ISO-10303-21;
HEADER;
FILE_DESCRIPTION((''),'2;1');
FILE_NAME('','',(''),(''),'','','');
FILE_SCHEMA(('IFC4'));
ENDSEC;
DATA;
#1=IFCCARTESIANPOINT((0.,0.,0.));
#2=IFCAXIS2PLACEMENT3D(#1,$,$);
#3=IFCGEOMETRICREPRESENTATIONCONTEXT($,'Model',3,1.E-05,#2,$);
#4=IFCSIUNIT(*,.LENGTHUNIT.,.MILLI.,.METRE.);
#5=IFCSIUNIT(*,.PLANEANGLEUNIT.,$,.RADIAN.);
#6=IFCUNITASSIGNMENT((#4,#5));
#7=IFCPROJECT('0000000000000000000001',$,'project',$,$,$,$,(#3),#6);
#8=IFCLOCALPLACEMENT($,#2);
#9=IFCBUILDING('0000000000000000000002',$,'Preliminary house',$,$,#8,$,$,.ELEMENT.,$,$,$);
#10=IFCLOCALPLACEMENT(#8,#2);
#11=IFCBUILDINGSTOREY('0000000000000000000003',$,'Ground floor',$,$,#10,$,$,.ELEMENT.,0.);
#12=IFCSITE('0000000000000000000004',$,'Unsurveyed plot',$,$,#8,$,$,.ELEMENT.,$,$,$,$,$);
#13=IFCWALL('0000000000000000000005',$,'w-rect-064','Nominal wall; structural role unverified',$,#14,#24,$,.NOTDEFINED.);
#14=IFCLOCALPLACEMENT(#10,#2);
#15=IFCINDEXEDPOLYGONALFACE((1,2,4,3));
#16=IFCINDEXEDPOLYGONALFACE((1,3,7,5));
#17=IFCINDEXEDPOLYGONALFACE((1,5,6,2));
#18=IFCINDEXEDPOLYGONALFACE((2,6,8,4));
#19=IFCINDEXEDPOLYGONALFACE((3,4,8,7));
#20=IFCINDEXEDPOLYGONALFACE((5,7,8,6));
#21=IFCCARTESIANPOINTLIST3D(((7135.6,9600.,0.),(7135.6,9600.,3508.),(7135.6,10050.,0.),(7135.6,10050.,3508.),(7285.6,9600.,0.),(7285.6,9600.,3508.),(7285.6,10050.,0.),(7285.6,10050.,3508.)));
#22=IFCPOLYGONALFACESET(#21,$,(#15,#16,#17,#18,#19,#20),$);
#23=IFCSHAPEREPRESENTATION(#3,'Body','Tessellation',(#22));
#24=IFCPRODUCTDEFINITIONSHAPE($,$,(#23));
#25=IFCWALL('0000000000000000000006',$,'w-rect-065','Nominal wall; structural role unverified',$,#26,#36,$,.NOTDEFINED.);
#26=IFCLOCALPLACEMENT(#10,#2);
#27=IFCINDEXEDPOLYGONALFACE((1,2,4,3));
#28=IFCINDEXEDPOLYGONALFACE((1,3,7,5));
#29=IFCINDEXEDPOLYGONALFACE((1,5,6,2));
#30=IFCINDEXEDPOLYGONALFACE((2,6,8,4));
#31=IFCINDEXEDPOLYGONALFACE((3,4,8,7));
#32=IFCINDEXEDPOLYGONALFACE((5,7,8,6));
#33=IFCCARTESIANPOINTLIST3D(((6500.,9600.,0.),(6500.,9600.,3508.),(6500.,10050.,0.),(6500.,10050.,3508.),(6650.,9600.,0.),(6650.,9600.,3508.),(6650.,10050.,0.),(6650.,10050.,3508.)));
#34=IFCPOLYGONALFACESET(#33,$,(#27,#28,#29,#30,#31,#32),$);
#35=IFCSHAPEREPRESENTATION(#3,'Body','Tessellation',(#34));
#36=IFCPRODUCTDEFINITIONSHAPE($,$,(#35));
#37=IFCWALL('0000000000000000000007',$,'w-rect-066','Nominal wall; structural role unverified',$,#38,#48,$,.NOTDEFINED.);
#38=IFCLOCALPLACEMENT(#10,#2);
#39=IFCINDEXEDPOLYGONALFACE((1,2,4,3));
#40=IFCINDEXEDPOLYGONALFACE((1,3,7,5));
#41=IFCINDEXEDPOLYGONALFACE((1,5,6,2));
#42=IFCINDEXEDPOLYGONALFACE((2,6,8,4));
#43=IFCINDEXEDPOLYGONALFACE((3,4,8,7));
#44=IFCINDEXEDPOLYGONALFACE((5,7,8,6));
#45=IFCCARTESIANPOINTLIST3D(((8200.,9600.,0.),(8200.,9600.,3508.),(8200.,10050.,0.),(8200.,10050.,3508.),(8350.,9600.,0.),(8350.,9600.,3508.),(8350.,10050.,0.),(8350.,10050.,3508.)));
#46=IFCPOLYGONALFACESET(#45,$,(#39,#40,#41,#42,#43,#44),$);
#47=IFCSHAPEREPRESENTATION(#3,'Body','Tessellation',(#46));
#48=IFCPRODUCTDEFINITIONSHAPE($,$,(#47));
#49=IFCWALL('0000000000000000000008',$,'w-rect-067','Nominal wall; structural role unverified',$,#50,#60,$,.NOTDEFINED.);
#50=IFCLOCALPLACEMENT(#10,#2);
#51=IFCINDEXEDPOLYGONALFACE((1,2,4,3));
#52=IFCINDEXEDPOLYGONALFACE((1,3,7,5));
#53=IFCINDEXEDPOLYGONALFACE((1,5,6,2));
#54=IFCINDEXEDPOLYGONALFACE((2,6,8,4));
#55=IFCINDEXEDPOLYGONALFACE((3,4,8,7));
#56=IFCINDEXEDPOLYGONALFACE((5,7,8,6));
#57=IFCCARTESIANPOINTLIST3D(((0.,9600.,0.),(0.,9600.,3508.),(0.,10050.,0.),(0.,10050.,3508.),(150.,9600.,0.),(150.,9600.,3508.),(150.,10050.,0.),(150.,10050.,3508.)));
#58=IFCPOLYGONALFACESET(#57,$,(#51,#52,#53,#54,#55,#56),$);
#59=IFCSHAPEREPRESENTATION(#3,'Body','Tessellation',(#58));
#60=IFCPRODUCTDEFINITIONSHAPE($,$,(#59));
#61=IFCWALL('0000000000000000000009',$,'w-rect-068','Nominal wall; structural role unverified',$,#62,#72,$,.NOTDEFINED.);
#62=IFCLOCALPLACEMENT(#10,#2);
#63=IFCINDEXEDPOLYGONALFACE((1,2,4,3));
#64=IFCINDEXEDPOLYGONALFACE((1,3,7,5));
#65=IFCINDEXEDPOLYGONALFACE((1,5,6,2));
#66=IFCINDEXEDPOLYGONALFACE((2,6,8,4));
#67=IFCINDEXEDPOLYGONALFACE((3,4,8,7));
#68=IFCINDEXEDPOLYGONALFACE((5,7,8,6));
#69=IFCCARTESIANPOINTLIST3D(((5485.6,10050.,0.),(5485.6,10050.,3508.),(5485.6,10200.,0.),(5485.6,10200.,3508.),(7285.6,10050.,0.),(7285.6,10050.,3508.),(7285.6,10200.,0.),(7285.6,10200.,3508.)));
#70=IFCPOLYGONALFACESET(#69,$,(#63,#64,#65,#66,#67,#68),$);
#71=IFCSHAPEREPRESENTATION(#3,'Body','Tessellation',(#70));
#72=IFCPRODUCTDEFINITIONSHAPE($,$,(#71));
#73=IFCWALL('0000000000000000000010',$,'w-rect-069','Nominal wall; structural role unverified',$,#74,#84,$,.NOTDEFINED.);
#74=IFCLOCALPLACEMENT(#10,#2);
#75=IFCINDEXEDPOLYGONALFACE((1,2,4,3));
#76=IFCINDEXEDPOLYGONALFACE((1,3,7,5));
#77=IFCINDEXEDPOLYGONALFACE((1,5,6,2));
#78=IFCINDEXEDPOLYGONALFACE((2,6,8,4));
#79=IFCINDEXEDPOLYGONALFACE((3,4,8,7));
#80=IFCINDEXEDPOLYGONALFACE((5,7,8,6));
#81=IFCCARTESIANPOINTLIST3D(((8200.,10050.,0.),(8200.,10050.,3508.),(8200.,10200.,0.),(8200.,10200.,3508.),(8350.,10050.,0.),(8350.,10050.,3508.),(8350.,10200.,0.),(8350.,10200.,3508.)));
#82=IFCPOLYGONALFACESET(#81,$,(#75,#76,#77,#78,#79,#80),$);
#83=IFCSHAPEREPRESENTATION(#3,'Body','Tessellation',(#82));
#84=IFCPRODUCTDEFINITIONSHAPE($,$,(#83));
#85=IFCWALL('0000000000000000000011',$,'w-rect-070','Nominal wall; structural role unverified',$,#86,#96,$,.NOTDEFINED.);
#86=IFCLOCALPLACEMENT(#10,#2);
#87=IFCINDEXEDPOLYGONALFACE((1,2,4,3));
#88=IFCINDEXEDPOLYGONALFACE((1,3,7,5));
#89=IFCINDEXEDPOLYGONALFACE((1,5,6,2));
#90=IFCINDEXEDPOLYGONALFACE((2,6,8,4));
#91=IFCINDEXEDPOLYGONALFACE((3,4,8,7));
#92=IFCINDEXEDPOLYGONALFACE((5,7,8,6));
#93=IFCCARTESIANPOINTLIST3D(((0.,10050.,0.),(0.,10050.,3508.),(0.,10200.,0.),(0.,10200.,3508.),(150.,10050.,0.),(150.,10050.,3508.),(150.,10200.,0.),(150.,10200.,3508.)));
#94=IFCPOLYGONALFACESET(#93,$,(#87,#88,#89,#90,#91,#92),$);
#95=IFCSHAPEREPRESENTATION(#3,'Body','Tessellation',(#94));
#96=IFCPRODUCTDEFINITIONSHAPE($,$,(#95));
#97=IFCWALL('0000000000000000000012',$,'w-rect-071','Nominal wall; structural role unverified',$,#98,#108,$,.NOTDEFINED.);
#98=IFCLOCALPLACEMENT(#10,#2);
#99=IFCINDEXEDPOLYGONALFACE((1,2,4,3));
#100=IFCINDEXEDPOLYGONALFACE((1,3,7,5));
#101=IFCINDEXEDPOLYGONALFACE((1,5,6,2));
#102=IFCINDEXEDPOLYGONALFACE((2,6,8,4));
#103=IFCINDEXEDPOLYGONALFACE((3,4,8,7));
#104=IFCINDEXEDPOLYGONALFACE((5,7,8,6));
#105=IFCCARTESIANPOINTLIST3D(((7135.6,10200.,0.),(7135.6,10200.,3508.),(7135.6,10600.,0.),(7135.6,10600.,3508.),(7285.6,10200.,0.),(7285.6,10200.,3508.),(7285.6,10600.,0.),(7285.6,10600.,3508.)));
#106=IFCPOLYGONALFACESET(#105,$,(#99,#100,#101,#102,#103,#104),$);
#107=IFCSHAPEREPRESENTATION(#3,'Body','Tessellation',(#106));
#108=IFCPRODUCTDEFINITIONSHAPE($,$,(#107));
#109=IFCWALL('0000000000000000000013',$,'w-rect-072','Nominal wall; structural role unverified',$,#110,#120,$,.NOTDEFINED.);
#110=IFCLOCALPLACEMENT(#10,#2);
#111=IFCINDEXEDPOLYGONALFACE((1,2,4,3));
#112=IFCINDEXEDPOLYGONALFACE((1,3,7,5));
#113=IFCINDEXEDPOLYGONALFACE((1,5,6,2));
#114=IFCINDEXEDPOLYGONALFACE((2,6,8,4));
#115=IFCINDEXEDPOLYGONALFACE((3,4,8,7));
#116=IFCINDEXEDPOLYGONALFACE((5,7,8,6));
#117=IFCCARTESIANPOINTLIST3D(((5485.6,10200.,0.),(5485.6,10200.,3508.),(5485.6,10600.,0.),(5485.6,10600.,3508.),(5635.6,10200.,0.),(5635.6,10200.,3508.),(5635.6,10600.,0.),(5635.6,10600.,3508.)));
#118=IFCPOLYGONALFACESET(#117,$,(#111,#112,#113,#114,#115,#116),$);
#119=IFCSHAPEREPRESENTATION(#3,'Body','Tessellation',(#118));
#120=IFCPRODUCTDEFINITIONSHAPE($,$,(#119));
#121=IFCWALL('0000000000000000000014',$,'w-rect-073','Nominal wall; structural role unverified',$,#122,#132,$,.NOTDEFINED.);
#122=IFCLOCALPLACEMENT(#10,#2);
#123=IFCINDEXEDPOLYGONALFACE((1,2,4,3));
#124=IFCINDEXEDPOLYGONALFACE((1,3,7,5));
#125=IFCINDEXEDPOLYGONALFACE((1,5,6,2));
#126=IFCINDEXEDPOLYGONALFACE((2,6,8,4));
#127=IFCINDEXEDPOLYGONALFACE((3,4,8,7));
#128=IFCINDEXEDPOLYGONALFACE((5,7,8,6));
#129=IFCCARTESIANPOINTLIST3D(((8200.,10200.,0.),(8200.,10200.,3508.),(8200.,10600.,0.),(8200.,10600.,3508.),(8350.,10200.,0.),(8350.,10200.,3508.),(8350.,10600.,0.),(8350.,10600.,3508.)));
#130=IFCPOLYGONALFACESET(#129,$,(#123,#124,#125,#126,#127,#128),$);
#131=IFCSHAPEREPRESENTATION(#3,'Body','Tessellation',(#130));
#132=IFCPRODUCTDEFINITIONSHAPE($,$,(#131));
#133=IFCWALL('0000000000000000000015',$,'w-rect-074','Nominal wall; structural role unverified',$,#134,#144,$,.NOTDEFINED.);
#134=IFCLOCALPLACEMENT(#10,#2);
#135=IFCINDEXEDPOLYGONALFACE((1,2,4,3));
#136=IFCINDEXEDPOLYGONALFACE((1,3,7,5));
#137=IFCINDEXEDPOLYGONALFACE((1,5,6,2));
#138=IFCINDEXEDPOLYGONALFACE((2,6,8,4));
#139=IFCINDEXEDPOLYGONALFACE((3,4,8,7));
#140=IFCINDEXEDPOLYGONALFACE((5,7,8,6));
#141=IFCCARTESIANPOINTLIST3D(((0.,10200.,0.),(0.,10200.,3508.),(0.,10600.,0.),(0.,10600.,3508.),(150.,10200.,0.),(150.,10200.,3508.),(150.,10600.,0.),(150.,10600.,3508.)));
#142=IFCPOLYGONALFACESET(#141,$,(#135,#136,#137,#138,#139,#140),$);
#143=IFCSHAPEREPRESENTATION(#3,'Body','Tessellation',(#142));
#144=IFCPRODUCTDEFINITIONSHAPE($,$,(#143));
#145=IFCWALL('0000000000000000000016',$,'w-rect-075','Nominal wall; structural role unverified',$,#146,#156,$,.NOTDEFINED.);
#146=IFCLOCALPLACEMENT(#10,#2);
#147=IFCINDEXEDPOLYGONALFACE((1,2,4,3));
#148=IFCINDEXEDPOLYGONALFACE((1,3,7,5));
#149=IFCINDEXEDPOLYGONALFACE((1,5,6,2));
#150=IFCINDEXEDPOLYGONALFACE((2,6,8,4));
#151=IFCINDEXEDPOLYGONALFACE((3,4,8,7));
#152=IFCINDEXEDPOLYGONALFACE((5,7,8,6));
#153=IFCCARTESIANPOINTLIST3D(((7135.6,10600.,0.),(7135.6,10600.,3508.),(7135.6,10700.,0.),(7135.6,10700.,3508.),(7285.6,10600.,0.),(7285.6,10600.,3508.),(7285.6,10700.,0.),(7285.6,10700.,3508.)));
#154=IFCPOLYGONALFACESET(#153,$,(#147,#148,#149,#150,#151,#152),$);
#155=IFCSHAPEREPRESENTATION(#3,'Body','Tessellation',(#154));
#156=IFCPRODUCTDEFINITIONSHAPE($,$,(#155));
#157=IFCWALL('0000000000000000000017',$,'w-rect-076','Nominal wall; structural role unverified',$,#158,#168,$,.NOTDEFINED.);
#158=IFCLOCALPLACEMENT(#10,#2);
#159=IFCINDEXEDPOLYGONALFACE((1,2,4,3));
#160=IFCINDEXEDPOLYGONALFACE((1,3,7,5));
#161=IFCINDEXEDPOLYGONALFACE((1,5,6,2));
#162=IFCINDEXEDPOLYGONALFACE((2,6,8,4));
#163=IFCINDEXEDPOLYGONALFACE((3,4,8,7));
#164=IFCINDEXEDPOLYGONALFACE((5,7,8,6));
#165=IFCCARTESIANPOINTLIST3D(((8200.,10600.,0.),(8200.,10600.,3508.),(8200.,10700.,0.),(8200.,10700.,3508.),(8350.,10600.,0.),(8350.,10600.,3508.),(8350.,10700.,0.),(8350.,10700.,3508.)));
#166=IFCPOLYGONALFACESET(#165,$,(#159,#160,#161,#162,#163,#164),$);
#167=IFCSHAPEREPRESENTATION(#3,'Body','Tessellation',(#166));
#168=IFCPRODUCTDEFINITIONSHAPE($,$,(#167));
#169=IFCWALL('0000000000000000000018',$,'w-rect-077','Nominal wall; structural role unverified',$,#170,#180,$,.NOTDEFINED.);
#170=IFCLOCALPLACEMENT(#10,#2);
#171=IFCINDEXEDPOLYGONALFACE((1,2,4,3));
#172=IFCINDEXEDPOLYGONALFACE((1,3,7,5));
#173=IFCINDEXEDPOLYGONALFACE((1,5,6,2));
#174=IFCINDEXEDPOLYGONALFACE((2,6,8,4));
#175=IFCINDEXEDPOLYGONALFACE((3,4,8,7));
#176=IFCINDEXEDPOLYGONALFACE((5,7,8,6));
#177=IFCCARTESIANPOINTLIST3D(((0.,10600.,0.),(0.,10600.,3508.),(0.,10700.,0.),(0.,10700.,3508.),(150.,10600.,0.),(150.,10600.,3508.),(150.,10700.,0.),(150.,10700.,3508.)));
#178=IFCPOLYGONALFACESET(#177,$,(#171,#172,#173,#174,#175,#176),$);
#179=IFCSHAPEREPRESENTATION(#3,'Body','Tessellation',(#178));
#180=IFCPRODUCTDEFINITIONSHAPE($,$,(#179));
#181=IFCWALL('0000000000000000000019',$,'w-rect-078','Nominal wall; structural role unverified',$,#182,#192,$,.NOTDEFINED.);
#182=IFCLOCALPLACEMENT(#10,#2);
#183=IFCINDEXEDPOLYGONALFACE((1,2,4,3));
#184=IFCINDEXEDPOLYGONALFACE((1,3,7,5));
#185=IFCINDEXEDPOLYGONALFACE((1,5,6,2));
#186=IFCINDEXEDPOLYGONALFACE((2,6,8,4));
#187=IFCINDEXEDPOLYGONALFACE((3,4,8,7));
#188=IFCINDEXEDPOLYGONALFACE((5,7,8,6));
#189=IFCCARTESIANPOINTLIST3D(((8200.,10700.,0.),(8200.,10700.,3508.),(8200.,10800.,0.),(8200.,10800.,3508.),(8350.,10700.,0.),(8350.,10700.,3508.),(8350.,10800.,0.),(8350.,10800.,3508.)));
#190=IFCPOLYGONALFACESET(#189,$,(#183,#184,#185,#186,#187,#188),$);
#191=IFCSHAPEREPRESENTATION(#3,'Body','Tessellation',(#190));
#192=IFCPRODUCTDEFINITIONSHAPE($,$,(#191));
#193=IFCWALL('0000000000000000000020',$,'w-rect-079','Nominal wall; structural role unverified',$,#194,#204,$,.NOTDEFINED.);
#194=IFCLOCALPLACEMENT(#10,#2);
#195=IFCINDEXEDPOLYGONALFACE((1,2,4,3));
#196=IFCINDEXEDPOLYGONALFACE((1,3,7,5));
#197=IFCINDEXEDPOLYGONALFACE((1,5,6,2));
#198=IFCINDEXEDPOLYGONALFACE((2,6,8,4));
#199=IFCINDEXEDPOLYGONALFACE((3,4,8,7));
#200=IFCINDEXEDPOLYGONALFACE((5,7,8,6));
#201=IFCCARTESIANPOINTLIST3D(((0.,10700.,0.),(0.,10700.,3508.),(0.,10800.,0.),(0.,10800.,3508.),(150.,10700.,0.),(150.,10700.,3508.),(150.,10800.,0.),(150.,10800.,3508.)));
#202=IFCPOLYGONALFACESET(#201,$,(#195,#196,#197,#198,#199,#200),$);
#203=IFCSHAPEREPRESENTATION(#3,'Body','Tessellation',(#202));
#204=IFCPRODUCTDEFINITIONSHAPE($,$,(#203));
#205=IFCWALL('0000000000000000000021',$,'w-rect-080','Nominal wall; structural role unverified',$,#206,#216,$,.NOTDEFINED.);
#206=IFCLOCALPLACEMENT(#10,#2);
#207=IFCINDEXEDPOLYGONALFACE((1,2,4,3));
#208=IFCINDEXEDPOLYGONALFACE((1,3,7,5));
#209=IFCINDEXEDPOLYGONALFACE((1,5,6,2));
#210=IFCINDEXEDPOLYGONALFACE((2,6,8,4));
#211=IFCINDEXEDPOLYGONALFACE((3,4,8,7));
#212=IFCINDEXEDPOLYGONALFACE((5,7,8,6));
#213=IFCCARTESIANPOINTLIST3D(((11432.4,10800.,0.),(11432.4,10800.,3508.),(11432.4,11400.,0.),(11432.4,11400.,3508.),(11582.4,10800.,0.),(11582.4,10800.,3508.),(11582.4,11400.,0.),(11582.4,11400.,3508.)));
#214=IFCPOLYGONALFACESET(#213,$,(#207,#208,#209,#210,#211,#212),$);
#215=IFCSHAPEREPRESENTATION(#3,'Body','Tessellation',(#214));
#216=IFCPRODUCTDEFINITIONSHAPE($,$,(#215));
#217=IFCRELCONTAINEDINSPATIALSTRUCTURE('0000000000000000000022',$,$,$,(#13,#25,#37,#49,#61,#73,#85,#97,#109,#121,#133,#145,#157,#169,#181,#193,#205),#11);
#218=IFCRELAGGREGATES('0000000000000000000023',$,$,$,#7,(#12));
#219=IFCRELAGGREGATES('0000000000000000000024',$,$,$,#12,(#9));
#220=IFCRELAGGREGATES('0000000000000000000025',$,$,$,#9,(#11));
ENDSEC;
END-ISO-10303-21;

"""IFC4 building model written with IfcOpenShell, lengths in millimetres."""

from ifc_helpers import new_model, si_unit, origin, place, context, project, spatial, polyline, outline, extrude, element, save


model = new_model("IFC4")

# Units and contexts
model_context = context("Model", 3, precision=1e-05, world=origin())
ifc_project = project(units=[si_unit("LENGTHUNIT", "METRE", prefix="MILLI"), si_unit("PLANEANGLEUNIT", "RADIAN")], contexts=[model_context])

# Site, building, storey
placement_1 = place(None, origin())
site = spatial("IfcSite", under=ifc_project, at=placement_1, Name="Unsurveyed plot", CompositionType="ELEMENT")
building = spatial("IfcBuilding", under=site, at=placement_1, Name="Preliminary house", CompositionType="ELEMENT")
placement_2 = place(placement_1, origin())
storey = spatial("IfcBuildingStorey", under=building, at=placement_2, Name="Ground floor", CompositionType="ELEMENT", Elevation=0.0)

# Walls
element("IfcWall", 1, at=placement_2, inside=storey, Name="w-rect-064", Description="Nominal wall; structural role unverified", PredefinedType="NOTDEFINED", context=model_context, shape_type="SweptSolid", body=[
    extrude(outline(polyline([(7135.6, 9600.0), (7285.6, 9600.0), (7285.6, 10050.0), (7135.6, 10050.0), (7135.6, 9600.0)])), origin(), (0.0, 0.0, 1.0), 3508.0),
])
element("IfcWall", 2, at=placement_2, inside=storey, Name="w-rect-065", Description="Nominal wall; structural role unverified", PredefinedType="NOTDEFINED", context=model_context, shape_type="SweptSolid", body=[
    extrude(outline(polyline([(6500.0, 9600.0), (6650.0, 9600.0), (6650.0, 10050.0), (6500.0, 10050.0), (6500.0, 9600.0)])), origin(), (0.0, 0.0, 1.0), 3508.0),
])
element("IfcWall", 3, at=placement_2, inside=storey, Name="w-rect-066", Description="Nominal wall; structural role unverified", PredefinedType="NOTDEFINED", context=model_context, shape_type="SweptSolid", body=[
    extrude(outline(polyline([(8200.0, 9600.0), (8350.0, 9600.0), (8350.0, 10050.0), (8200.0, 10050.0), (8200.0, 9600.0)])), origin(), (0.0, 0.0, 1.0), 3508.0),
])
element("IfcWall", 4, at=placement_2, inside=storey, Name="w-rect-067", Description="Nominal wall; structural role unverified", PredefinedType="NOTDEFINED", context=model_context, shape_type="SweptSolid", body=[
    extrude(outline(polyline([(0.0, 9600.0), (150.0, 9600.0), (150.0, 10050.0), (0.0, 10050.0), (0.0, 9600.0)])), origin(), (0.0, 0.0, 1.0), 3508.0),
])
element("IfcWall", 5, at=placement_2, inside=storey, Name="w-rect-068", Description="Nominal wall; structural role unverified", PredefinedType="NOTDEFINED", context=model_context, shape_type="SweptSolid", body=[
    extrude(outline(polyline([(5485.6, 10050.0), (7285.6, 10050.0), (7285.6, 10200.0), (5485.6, 10200.0), (5485.6, 10050.0)])), origin(), (0.0, 0.0, 1.0), 3508.0),
])
element("IfcWall", 6, at=placement_2, inside=storey, Name="w-rect-069", Description="Nominal wall; structural role unverified", PredefinedType="NOTDEFINED", context=model_context, shape_type="SweptSolid", body=[
    extrude(outline(polyline([(8200.0, 10050.0), (8350.0, 10050.0), (8350.0, 10200.0), (8200.0, 10200.0), (8200.0, 10050.0)])), origin(), (0.0, 0.0, 1.0), 3508.0),
])
element("IfcWall", 7, at=placement_2, inside=storey, Name="w-rect-070", Description="Nominal wall; structural role unverified", PredefinedType="NOTDEFINED", context=model_context, shape_type="SweptSolid", body=[
    extrude(outline(polyline([(0.0, 10050.0), (150.0, 10050.0), (150.0, 10200.0), (0.0, 10200.0), (0.0, 10050.0)])), origin(), (0.0, 0.0, 1.0), 3508.0),
])
element("IfcWall", 8, at=placement_2, inside=storey, Name="w-rect-071", Description="Nominal wall; structural role unverified", PredefinedType="NOTDEFINED", context=model_context, shape_type="SweptSolid", body=[
    extrude(outline(polyline([(7135.6, 10200.0), (7285.6, 10200.0), (7285.6, 10600.0), (7135.6, 10600.0), (7135.6, 10200.0)])), origin(), (0.0, 0.0, 1.0), 3508.0),
])
element("IfcWall", 9, at=placement_2, inside=storey, Name="w-rect-072", Description="Nominal wall; structural role unverified", PredefinedType="NOTDEFINED", context=model_context, shape_type="SweptSolid", body=[
    extrude(outline(polyline([(5485.6, 10200.0), (5635.6, 10200.0), (5635.6, 10600.0), (5485.6, 10600.0), (5485.6, 10200.0)])), origin(), (0.0, 0.0, 1.0), 3508.0),
])
element("IfcWall", 10, at=placement_2, inside=storey, Name="w-rect-073", Description="Nominal wall; structural role unverified", PredefinedType="NOTDEFINED", context=model_context, shape_type="SweptSolid", body=[
    extrude(outline(polyline([(8200.0, 10200.0), (8350.0, 10200.0), (8350.0, 10600.0), (8200.0, 10600.0), (8200.0, 10200.0)])), origin(), (0.0, 0.0, 1.0), 3508.0),
])
element("IfcWall", 11, at=placement_2, inside=storey, Name="w-rect-074", Description="Nominal wall; structural role unverified", PredefinedType="NOTDEFINED", context=model_context, shape_type="SweptSolid", body=[
    extrude(outline(polyline([(0.0, 10200.0), (150.0, 10200.0), (150.0, 10600.0), (0.0, 10600.0), (0.0, 10200.0)])), origin(), (0.0, 0.0, 1.0), 3508.0),
])
element("IfcWall", 12, at=placement_2, inside=storey, Name="w-rect-075", Description="Nominal wall; structural role unverified", PredefinedType="NOTDEFINED", context=model_context, shape_type="SweptSolid", body=[
    extrude(outline(polyline([(7135.6, 10600.0), (7285.6, 10600.0), (7285.6, 10700.0), (7135.6, 10700.0), (7135.6, 10600.0)])), origin(), (0.0, 0.0, 1.0), 3508.0),
])
element("IfcWall", 13, at=placement_2, inside=storey, Name="w-rect-076", Description="Nominal wall; structural role unverified", PredefinedType="NOTDEFINED", context=model_context, shape_type="SweptSolid", body=[
    extrude(outline(polyline([(8200.0, 10600.0), (8350.0, 10600.0), (8350.0, 10700.0), (8200.0, 10700.0), (8200.0, 10600.0)])), origin(), (0.0, 0.0, 1.0), 3508.0),
])
element("IfcWall", 14, at=placement_2, inside=storey, Name="w-rect-077", Description="Nominal wall; structural role unverified", PredefinedType="NOTDEFINED", context=model_context, shape_type="SweptSolid", body=[
    extrude(outline(polyline([(0.0, 10600.0), (150.0, 10600.0), (150.0, 10700.0), (0.0, 10700.0), (0.0, 10600.0)])), origin(), (0.0, 0.0, 1.0), 3508.0),
])
element("IfcWall", 15, at=placement_2, inside=storey, Name="w-rect-078", Description="Nominal wall; structural role unverified", PredefinedType="NOTDEFINED", context=model_context, shape_type="SweptSolid", body=[
    extrude(outline(polyline([(8200.0, 10700.0), (8350.0, 10700.0), (8350.0, 10800.0), (8200.0, 10800.0), (8200.0, 10700.0)])), origin(), (0.0, 0.0, 1.0), 3508.0),
])
element("IfcWall", 16, at=placement_2, inside=storey, Name="w-rect-079", Description="Nominal wall; structural role unverified", PredefinedType="NOTDEFINED", context=model_context, shape_type="SweptSolid", body=[
    extrude(outline(polyline([(0.0, 10700.0), (150.0, 10700.0), (150.0, 10800.0), (0.0, 10800.0), (0.0, 10700.0)])), origin(), (0.0, 0.0, 1.0), 3508.0),
])
element("IfcWall", 17, at=placement_2, inside=storey, Name="w-rect-080", Description="Nominal wall; structural role unverified", PredefinedType="NOTDEFINED", context=model_context, shape_type="SweptSolid", body=[
    extrude(outline(polyline([(11432.4, 10800.0), (11582.4, 10800.0), (11582.4, 11400.0), (11432.4, 11400.0), (11432.4, 10800.0)])), origin(), (0.0, 0.0, 1.0), 3508.0),
])

save(model, "model.ifc")
